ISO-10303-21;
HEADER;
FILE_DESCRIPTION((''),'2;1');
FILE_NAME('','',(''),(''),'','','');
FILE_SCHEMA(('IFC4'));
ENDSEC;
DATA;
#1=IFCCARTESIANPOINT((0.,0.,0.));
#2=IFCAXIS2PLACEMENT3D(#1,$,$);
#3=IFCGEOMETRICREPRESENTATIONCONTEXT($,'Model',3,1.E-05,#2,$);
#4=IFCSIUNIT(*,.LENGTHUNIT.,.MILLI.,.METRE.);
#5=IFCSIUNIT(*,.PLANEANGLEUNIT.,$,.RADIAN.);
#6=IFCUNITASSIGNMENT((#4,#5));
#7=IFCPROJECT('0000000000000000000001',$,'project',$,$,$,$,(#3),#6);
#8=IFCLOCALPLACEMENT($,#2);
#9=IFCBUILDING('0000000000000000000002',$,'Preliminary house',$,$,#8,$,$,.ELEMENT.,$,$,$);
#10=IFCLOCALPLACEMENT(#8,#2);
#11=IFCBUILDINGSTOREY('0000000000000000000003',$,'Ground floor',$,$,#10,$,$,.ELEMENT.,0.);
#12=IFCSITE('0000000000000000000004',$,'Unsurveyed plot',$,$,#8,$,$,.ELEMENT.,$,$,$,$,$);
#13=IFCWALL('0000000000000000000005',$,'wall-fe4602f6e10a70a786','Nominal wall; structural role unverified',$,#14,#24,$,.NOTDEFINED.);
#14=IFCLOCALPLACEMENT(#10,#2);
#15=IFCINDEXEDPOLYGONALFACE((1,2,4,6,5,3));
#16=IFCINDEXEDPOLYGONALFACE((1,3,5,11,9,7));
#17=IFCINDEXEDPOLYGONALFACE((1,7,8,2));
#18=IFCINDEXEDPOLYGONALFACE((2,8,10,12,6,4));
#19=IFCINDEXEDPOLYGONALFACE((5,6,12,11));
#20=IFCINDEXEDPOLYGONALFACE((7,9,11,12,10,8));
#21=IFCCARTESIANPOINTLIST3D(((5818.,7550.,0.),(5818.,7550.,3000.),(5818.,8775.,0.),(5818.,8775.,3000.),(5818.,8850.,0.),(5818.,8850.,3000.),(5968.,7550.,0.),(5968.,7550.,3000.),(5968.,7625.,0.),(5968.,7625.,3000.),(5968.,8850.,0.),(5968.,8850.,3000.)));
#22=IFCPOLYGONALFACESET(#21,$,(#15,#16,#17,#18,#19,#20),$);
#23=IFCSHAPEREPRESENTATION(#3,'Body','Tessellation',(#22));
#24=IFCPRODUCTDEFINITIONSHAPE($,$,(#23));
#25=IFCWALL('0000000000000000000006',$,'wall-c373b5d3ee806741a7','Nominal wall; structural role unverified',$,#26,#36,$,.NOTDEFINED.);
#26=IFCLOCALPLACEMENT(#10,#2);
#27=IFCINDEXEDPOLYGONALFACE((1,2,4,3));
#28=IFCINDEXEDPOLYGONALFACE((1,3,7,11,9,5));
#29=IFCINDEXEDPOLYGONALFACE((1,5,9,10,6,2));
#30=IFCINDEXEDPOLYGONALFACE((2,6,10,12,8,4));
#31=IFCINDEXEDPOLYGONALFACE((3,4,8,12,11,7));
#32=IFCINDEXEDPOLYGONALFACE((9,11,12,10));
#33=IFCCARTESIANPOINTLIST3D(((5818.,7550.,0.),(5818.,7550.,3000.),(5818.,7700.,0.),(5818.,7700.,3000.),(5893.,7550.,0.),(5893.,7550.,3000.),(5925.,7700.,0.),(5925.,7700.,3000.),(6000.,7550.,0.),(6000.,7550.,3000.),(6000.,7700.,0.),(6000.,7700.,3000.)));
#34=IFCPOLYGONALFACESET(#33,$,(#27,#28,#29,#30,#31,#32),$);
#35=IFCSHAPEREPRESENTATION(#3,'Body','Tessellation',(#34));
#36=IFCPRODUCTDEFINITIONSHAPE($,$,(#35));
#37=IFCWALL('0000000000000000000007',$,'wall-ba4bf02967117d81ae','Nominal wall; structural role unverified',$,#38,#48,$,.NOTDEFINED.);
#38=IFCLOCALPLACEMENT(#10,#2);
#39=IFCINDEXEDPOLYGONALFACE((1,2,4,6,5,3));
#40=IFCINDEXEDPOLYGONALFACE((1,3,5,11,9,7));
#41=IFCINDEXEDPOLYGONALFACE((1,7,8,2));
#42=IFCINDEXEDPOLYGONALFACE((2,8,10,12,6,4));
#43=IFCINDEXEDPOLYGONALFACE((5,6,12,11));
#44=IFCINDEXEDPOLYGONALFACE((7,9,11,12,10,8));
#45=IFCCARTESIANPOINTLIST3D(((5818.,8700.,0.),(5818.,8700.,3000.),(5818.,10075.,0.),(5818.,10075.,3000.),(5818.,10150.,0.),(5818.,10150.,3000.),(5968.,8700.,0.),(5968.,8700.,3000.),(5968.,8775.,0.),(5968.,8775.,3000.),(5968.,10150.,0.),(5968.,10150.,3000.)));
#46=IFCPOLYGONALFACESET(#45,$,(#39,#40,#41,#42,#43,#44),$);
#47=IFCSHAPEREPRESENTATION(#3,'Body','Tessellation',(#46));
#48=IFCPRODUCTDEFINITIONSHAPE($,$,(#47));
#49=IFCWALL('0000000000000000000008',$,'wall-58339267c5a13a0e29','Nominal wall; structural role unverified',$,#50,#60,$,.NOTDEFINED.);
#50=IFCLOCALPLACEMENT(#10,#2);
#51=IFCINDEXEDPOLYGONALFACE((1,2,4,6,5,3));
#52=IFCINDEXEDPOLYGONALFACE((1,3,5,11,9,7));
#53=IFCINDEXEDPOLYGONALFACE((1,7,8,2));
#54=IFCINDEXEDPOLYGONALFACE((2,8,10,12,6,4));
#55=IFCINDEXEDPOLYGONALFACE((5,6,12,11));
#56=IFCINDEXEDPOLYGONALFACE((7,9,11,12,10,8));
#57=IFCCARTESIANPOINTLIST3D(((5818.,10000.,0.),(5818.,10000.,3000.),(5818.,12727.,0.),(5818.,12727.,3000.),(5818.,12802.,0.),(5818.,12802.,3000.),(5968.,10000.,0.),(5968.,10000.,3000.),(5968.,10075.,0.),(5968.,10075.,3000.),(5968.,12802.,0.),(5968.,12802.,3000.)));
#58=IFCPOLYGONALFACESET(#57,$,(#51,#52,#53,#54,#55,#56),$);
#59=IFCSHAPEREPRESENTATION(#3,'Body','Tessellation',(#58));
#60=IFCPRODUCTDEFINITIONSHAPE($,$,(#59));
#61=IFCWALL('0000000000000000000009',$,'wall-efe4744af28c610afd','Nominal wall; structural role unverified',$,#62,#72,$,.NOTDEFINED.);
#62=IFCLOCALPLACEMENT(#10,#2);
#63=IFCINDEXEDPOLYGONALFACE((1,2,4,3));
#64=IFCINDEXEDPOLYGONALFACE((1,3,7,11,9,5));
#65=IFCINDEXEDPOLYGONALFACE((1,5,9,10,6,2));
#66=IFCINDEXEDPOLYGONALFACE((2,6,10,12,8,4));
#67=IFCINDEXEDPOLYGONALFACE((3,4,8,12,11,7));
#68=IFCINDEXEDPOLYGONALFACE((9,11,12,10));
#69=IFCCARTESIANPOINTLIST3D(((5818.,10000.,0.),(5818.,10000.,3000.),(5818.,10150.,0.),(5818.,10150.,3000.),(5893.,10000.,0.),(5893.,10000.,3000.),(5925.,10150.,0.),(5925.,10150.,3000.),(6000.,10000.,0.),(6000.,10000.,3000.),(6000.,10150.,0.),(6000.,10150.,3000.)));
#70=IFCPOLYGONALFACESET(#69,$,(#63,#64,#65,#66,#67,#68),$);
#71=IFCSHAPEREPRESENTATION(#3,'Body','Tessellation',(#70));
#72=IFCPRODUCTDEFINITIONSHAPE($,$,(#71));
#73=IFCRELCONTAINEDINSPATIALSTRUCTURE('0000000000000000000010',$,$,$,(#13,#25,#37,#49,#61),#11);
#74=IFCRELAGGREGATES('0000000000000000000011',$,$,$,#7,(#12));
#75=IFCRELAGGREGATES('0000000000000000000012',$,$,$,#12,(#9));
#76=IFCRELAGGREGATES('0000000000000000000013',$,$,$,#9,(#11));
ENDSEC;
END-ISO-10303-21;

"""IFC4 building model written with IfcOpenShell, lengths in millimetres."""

from ifc_helpers import new_model, si_unit, origin, place, context, project, spatial, polyline, outline, extrude, element, save


model = new_model("IFC4")

# Units and contexts
model_context = context("Model", 3, precision=1e-05, world=origin())
ifc_project = project(units=[si_unit("LENGTHUNIT", "METRE", prefix="MILLI"), si_unit("PLANEANGLEUNIT", "RADIAN")], contexts=[model_context])

# Site, building, storey
placement_1 = place(None, origin())
site = spatial("IfcSite", under=ifc_project, at=placement_1, Name="Unsurveyed plot", CompositionType="ELEMENT")
building = spatial("IfcBuilding", under=site, at=placement_1, Name="Preliminary house", CompositionType="ELEMENT")
placement_2 = place(placement_1, origin())
storey = spatial("IfcBuildingStorey", under=building, at=placement_2, Name="Ground floor", CompositionType="ELEMENT", Elevation=0.0)

# Walls
element("IfcWall", 1, at=placement_2, inside=storey, Name="wall-fe4602f6e10a70a786", Description="Nominal wall; structural role unverified", PredefinedType="NOTDEFINED", context=model_context, shape_type="SweptSolid", body=[
    extrude(outline(polyline([(5818.0, 8775.0), (5818.0, 8850.0), (5968.0, 8850.0), (5968.0, 7625.0), (5968.0, 7550.0), (5818.0, 7550.0), (5818.0, 8775.0)])), origin(), (0.0, 0.0, 1.0), 3000.0),
])
element("IfcWall", 2, at=placement_2, inside=storey, Name="wall-c373b5d3ee806741a7", Description="Nominal wall; structural role unverified", PredefinedType="NOTDEFINED", context=model_context, shape_type="SweptSolid", body=[
    extrude(outline(polyline([(5925.0, 7700.0), (6000.0, 7700.0), (6000.0, 7550.0), (5893.0, 7550.0), (5818.0, 7550.0), (5818.0, 7700.0), (5925.0, 7700.0)])), origin(), (0.0, 0.0, 1.0), 3000.0),
])
element("IfcWall", 3, at=placement_2, inside=storey, Name="wall-ba4bf02967117d81ae", Description="Nominal wall; structural role unverified", PredefinedType="NOTDEFINED", context=model_context, shape_type="SweptSolid", body=[
    extrude(outline(polyline([(5818.0, 10075.0), (5818.0, 10150.0), (5968.0, 10150.0), (5968.0, 8775.0), (5968.0, 8700.0), (5818.0, 8700.0), (5818.0, 10075.0)])), origin(), (0.0, 0.0, 1.0), 3000.0),
])
element("IfcWall", 4, at=placement_2, inside=storey, Name="wall-58339267c5a13a0e29", Description="Nominal wall; structural role unverified", PredefinedType="NOTDEFINED", context=model_context, shape_type="SweptSolid", body=[
    extrude(outline(polyline([(5818.0, 12727.0), (5818.0, 12802.0), (5968.0, 12802.0), (5968.0, 10075.0), (5968.0, 10000.0), (5818.0, 10000.0), (5818.0, 12727.0)])), origin(), (0.0, 0.0, 1.0), 3000.0),
])
element("IfcWall", 5, at=placement_2, inside=storey, Name="wall-efe4744af28c610afd", Description="Nominal wall; structural role unverified", PredefinedType="NOTDEFINED", context=model_context, shape_type="SweptSolid", body=[
    extrude(outline(polyline([(5925.0, 10150.0), (6000.0, 10150.0), (6000.0, 10000.0), (5893.0, 10000.0), (5818.0, 10000.0), (5818.0, 10150.0), (5925.0, 10150.0)])), origin(), (0.0, 0.0, 1.0), 3000.0),
])

save(model, "model.ifc")
